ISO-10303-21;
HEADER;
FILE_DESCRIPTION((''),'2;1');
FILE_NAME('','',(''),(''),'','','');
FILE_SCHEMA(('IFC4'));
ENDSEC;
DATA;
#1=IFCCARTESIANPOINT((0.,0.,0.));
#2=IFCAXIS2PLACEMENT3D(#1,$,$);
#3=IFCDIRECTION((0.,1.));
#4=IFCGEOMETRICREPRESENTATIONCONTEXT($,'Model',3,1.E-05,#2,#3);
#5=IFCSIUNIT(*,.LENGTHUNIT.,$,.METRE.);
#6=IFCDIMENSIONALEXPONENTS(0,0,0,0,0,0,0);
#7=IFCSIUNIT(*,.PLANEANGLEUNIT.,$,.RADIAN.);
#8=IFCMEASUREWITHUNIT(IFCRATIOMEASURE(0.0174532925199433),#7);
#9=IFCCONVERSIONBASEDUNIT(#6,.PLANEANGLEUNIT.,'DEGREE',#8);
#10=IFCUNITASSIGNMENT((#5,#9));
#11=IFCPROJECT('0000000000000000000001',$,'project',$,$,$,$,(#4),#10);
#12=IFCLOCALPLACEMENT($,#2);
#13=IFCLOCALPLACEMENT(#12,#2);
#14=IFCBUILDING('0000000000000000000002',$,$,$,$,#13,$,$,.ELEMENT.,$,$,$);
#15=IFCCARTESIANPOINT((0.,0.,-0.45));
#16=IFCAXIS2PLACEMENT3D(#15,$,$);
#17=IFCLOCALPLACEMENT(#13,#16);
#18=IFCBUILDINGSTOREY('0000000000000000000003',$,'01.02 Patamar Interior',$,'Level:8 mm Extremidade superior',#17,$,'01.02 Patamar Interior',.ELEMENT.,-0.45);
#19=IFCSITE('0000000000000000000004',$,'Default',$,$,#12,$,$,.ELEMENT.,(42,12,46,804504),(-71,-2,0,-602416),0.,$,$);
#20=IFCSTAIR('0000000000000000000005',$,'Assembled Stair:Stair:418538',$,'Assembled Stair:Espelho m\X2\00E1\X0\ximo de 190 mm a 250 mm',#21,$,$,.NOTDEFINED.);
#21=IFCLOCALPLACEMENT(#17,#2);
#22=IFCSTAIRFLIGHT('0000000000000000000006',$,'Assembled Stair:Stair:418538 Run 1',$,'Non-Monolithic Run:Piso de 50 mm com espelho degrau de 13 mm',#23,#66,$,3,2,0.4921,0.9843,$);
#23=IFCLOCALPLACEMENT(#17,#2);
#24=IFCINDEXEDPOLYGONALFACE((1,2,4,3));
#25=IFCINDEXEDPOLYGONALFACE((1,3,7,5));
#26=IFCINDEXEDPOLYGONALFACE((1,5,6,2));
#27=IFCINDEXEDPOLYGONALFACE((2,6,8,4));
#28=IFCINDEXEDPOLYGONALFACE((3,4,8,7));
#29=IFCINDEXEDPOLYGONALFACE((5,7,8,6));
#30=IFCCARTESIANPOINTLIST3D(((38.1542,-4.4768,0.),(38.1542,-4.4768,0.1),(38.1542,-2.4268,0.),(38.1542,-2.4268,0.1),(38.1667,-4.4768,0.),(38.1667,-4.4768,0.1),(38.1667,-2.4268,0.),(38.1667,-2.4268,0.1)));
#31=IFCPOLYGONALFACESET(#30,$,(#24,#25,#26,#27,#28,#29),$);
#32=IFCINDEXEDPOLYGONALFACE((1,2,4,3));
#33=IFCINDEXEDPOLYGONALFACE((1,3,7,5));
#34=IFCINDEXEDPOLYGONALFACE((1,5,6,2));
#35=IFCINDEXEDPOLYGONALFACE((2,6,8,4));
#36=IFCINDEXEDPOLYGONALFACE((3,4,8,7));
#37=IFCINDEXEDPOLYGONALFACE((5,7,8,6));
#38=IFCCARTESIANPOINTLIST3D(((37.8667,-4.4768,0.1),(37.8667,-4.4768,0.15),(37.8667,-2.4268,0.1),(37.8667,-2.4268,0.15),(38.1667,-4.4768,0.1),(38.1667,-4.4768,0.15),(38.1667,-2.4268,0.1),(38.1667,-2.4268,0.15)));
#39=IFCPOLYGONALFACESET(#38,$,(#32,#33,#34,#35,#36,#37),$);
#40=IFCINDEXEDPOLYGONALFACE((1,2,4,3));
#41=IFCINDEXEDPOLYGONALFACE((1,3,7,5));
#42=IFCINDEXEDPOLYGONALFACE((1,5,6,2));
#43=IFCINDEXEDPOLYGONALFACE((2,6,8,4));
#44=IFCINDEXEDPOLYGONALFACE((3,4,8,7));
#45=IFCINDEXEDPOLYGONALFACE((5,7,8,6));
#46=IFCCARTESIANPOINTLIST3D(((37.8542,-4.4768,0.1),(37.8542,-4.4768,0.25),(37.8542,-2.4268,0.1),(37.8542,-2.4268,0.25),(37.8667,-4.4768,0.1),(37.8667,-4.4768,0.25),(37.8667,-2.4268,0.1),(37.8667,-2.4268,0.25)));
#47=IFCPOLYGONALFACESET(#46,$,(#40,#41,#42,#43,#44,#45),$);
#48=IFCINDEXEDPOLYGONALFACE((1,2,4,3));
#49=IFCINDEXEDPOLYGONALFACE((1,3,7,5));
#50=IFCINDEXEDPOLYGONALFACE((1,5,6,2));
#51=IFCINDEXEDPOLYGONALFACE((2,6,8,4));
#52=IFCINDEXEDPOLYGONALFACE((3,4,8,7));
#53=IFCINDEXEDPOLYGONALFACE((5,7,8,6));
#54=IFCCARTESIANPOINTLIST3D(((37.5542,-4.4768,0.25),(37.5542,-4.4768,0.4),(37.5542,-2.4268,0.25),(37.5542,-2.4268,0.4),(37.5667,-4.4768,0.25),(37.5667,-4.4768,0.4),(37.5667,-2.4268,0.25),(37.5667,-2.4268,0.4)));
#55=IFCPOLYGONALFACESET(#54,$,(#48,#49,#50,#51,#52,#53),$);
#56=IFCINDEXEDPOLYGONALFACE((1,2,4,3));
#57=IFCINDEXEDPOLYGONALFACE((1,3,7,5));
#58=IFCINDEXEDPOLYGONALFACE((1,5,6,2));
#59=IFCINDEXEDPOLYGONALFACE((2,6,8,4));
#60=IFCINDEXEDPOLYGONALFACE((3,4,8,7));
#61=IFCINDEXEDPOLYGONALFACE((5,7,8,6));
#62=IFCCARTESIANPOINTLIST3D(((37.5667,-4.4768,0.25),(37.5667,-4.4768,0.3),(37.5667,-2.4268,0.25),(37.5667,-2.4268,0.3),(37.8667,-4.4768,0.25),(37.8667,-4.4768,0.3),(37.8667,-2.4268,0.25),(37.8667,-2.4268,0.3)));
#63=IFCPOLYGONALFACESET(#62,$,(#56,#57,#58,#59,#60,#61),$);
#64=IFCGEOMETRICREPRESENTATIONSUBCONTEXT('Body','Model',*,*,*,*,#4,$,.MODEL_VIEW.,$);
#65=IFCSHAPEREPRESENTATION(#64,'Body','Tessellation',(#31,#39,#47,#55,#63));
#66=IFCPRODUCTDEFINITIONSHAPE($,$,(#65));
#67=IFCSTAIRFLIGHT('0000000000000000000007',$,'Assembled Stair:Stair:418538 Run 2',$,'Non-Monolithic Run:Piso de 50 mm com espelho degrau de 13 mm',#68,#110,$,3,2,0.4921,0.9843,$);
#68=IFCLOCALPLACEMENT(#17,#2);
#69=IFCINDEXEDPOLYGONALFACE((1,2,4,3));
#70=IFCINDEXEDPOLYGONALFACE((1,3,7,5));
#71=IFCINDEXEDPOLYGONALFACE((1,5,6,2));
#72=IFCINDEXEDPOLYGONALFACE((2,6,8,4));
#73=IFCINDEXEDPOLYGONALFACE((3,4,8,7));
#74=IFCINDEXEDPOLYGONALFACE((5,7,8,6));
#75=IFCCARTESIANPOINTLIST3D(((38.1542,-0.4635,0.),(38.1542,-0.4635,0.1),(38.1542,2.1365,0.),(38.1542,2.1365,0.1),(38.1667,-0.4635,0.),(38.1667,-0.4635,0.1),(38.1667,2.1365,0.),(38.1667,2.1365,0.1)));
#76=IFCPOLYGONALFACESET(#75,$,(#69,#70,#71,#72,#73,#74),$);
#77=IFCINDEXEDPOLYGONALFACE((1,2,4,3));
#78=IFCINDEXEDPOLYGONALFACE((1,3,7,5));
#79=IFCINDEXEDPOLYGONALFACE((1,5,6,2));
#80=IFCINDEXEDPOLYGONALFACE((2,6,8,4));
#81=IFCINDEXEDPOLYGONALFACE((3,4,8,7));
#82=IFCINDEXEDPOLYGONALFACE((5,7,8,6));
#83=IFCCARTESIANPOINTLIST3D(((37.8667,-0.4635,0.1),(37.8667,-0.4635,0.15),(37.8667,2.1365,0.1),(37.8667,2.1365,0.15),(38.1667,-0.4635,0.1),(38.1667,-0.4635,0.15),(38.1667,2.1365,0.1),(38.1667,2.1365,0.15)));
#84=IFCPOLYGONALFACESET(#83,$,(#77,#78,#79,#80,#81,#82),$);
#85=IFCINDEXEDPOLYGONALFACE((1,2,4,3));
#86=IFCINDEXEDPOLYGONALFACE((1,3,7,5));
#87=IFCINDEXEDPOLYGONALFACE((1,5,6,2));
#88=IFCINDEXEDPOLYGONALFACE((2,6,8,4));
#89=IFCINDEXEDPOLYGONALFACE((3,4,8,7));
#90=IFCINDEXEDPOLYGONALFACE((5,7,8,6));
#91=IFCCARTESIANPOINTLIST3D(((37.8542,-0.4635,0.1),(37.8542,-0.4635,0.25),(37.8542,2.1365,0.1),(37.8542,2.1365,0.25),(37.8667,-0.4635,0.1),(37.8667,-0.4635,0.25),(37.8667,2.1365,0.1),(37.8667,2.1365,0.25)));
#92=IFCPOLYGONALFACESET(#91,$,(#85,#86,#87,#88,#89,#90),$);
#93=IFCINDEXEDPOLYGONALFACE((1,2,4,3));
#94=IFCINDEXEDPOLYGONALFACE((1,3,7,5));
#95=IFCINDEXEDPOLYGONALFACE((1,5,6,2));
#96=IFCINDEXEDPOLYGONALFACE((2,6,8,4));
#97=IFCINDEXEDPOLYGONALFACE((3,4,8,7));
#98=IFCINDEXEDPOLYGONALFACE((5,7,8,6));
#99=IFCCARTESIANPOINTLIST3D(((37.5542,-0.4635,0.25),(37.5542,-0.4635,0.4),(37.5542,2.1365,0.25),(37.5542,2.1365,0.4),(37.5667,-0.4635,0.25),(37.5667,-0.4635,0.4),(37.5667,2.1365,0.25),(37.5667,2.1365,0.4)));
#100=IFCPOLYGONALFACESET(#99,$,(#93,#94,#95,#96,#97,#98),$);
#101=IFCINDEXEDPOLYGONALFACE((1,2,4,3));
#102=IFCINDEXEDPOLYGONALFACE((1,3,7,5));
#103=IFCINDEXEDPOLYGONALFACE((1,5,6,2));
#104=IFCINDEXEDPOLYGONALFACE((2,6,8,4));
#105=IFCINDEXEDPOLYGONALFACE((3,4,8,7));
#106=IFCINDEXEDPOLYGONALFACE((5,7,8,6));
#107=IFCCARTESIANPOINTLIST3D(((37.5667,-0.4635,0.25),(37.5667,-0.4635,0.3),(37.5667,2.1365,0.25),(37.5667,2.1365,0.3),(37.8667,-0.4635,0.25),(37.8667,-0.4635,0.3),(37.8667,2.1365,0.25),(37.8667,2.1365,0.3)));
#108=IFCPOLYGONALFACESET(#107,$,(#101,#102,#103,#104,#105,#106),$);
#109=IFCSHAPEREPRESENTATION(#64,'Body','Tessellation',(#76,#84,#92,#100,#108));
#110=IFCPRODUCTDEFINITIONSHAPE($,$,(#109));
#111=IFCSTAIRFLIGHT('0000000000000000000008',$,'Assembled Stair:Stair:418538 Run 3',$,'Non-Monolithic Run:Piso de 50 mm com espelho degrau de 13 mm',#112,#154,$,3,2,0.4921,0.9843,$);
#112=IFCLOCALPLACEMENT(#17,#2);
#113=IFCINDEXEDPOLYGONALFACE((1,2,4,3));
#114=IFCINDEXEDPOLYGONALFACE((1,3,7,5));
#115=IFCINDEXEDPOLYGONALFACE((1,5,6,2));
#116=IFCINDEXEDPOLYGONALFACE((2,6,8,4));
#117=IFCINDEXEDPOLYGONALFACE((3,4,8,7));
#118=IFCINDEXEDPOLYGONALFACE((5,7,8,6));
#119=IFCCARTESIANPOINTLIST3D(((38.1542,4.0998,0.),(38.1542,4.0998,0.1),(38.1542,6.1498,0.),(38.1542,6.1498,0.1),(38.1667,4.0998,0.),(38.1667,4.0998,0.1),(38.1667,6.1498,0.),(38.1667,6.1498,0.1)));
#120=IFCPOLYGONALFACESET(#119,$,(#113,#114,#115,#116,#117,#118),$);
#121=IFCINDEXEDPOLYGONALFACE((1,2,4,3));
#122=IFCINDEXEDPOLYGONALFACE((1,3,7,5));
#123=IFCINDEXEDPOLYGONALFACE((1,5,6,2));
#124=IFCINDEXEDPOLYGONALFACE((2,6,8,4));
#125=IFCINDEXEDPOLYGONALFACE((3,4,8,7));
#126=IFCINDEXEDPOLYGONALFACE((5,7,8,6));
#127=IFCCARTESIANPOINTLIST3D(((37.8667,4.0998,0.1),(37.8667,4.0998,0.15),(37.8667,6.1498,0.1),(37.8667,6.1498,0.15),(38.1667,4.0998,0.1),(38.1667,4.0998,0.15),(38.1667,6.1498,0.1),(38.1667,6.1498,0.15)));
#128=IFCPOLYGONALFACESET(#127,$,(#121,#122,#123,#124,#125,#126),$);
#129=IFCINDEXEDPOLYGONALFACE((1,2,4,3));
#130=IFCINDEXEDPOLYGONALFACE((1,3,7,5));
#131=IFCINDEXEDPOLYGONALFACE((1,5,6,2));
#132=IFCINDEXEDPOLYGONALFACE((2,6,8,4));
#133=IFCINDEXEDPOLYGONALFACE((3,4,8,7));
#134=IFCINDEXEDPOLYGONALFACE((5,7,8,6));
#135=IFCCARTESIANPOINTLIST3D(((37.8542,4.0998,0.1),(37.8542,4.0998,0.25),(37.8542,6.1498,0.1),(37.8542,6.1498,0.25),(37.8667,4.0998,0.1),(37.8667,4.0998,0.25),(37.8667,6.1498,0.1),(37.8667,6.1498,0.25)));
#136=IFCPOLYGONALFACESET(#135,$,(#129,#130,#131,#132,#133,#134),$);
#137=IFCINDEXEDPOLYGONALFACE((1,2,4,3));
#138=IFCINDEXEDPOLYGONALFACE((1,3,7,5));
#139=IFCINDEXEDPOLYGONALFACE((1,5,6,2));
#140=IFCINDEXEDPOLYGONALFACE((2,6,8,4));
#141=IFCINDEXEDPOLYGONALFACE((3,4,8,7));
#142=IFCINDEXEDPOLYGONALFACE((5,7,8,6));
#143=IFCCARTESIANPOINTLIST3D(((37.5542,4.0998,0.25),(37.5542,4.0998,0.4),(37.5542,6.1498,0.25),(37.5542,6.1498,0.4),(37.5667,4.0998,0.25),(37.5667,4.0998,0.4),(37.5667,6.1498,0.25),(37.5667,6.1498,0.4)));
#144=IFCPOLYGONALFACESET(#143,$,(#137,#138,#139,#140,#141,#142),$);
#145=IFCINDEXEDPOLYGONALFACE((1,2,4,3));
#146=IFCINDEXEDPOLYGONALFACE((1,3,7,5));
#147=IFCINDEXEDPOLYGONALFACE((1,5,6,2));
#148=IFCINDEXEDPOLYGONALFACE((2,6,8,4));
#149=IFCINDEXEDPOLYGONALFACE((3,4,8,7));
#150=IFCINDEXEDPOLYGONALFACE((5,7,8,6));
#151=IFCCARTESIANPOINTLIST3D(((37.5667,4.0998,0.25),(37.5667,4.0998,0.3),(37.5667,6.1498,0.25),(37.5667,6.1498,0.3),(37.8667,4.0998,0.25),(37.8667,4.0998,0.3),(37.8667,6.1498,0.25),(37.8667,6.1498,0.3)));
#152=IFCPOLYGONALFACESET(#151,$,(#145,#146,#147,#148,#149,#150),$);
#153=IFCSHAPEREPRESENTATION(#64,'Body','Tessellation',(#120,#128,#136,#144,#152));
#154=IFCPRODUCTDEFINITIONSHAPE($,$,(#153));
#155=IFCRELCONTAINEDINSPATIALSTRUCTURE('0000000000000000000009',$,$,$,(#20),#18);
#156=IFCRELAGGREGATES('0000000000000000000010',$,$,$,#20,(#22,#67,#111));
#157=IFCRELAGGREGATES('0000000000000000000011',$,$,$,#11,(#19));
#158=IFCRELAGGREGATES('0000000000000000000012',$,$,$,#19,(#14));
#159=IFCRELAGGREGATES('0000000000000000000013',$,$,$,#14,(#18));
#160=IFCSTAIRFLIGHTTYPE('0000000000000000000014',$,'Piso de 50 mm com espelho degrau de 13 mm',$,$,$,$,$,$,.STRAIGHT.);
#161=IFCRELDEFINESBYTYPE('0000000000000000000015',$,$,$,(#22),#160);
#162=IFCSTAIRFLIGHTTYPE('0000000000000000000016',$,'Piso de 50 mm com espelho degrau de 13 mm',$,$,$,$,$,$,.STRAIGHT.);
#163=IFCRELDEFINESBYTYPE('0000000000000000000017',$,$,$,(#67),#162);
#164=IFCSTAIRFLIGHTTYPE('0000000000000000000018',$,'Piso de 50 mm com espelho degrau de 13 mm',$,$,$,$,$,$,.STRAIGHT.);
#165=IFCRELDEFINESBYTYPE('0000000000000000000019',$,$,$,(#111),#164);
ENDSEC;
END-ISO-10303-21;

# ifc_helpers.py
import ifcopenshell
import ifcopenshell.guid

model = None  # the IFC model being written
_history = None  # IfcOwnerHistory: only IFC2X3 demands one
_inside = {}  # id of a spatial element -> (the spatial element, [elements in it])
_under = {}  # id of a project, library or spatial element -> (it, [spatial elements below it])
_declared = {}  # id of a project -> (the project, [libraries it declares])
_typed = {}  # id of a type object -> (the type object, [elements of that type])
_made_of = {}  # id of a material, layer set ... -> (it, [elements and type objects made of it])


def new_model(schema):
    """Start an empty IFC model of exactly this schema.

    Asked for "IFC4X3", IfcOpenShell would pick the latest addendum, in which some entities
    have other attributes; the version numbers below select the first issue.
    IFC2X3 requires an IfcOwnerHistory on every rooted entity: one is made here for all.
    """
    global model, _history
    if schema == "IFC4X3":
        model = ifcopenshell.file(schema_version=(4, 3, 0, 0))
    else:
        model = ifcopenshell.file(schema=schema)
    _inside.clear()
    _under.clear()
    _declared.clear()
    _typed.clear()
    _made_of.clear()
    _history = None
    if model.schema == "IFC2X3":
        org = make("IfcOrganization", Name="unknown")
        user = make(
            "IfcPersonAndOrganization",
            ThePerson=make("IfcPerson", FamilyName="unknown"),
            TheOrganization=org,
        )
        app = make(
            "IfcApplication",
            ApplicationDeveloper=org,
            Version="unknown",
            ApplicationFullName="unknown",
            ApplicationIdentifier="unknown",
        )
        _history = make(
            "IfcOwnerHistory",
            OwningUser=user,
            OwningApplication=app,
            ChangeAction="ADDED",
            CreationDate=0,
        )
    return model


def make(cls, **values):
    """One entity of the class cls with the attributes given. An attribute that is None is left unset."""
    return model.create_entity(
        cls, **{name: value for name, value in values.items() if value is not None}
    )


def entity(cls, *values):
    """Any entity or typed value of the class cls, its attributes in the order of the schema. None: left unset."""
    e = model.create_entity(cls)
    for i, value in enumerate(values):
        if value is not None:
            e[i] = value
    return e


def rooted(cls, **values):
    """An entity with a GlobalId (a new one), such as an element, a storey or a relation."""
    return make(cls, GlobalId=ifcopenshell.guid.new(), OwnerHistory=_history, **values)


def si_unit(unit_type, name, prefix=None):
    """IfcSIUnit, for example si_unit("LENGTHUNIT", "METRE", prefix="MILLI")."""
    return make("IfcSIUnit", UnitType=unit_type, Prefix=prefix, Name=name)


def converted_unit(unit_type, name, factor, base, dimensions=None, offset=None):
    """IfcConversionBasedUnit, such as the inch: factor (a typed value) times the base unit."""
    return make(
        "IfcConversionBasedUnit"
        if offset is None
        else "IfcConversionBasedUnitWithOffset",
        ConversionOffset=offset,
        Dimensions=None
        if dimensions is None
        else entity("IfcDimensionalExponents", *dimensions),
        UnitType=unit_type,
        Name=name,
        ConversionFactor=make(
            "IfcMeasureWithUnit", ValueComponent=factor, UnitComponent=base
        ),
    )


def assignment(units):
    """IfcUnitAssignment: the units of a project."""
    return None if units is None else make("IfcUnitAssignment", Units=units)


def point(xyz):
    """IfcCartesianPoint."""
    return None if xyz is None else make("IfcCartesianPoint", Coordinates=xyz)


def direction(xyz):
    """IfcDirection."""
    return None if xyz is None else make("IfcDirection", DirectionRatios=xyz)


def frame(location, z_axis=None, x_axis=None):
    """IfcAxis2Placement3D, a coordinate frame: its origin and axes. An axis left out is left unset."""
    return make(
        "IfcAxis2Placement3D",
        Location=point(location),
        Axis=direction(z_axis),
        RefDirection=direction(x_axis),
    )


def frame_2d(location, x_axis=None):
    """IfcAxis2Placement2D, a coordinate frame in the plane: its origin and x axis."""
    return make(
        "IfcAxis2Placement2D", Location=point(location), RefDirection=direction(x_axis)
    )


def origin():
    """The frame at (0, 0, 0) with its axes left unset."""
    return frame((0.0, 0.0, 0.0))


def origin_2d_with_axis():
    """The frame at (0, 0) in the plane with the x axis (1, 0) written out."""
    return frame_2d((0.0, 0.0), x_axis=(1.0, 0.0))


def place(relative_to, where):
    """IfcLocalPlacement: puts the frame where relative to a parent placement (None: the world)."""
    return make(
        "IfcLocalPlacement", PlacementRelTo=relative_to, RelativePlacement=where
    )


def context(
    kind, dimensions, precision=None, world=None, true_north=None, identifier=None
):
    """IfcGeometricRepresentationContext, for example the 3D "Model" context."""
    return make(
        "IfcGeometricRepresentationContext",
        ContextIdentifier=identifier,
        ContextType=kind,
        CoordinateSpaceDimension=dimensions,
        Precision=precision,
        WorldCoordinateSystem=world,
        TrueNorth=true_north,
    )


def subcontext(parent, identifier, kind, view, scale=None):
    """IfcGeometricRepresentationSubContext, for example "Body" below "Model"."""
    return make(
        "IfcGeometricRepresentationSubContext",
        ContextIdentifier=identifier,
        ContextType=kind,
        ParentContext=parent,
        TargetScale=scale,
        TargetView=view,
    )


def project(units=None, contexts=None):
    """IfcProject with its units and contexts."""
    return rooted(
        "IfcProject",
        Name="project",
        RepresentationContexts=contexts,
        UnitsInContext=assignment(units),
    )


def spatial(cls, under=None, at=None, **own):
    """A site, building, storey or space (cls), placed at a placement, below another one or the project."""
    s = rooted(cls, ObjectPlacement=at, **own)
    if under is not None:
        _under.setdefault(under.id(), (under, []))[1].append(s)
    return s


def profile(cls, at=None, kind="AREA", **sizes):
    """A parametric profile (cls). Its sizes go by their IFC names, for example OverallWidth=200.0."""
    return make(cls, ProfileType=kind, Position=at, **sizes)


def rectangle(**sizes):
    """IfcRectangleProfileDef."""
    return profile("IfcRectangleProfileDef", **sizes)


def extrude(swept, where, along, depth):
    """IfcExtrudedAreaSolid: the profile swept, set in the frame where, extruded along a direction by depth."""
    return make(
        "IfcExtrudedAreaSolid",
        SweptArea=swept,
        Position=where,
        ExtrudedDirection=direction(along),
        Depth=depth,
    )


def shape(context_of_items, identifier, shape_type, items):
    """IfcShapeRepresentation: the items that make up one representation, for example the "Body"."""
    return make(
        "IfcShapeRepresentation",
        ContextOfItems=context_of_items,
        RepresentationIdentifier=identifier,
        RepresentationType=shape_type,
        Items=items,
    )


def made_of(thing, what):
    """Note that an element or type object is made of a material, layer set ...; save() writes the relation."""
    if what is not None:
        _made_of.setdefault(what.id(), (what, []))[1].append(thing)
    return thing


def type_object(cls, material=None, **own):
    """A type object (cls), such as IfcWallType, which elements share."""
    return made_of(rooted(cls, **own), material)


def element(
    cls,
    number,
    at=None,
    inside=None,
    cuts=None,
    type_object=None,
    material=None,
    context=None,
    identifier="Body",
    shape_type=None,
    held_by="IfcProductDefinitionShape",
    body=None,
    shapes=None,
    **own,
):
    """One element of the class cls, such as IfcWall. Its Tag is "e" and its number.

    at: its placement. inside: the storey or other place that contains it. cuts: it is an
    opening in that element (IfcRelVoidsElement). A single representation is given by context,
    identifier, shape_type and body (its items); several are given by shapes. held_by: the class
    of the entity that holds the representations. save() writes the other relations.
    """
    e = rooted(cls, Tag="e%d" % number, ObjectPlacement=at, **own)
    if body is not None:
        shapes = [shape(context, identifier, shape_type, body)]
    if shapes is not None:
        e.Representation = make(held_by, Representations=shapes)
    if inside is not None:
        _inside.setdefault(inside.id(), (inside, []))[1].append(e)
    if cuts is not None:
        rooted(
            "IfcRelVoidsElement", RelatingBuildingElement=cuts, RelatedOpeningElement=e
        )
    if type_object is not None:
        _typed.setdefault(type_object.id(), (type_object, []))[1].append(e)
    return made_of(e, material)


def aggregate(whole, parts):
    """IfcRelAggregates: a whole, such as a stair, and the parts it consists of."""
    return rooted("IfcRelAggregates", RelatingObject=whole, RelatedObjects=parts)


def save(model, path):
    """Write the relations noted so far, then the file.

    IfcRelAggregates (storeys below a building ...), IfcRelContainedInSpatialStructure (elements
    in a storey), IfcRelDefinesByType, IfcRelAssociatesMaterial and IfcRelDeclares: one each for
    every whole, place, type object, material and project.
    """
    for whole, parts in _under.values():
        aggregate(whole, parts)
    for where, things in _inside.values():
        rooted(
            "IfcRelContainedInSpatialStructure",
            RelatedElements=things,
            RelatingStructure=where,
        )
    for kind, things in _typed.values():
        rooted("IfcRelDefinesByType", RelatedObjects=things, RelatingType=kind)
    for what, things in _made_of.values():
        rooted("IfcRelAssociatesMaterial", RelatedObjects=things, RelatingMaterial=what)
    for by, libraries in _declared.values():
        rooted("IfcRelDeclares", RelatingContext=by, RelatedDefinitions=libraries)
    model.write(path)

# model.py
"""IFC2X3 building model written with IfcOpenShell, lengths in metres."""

from ifc_helpers import new_model, entity, si_unit, converted_unit, direction, frame, frame_2d, origin, origin_2d_with_axis, place, context, subcontext, project, spatial, rectangle, extrude, type_object, element, aggregate, save


model = new_model("IFC2X3")

# Units and contexts
model_context = context("Model", 3, precision=1e-05, world=origin(), true_north=direction((0.0, 1.0)))
body_context = subcontext(model_context, "Body", "Model", "MODEL_VIEW")
ifc_project = project(units=[si_unit("LENGTHUNIT", "METRE"), converted_unit("PLANEANGLEUNIT", "DEGREE", entity("IfcRatioMeasure", 0.0174532925199433), si_unit("PLANEANGLEUNIT", "RADIAN"), dimensions=[0, 0, 0, 0, 0, 0, 0])], contexts=[model_context])

# Site, building, storey
site_placement = place(None, origin())
site = spatial("IfcSite", under=ifc_project, at=site_placement, Name="Default", CompositionType="ELEMENT", RefLatitude=(42, 12, 46, 804504), RefLongitude=(-71, -2, 0, -602416), RefElevation=0.0)
building_placement = place(site_placement, origin())
building = spatial("IfcBuilding", under=site, at=building_placement, CompositionType="ELEMENT")
storey_placement = place(building_placement, frame((0.0, 0.0, -0.45)))
storey = spatial("IfcBuildingStorey", under=building, at=storey_placement, Name="01.02 Patamar Interior", ObjectType="Level:8 mm Extremidade superior", LongName="01.02 Patamar Interior", CompositionType="ELEMENT", Elevation=-0.45)

# Stair, stair flights
stair_placement = place(storey_placement, origin())
stair = element("IfcStair", 1, at=stair_placement, inside=storey, Name="Assembled Stair:Stair:418538", ObjectType="Assembled Stair:Espelho máximo de 190 mm a 250 mm", ShapeType="NOTDEFINED")
stair_flight_type_1 = type_object("IfcStairFlightType", Name="Piso de 50 mm com espelho degrau de 13 mm", PredefinedType="STRAIGHT")
stair_flight_1_placement = place(stair_placement, frame((37.5542, -4.4768, 0.0)))
stair_flight_1 = element("IfcStairFlight", 2, at=stair_flight_1_placement, type_object=stair_flight_type_1, Name="Assembled Stair:Stair:418538 Run 1", ObjectType="Non-Monolithic Run:Piso de 50 mm com espelho degrau de 13 mm", NumberOfRiser=3, NumberOfTreads=2, RiserHeight=0.4921, TreadLength=0.9843, context=body_context, shape_type="SweptSolid", body=[
    extrude(rectangle(XDim=2.05, YDim=0.0125, at=frame_2d((0.0, 0.0), x_axis=(1.0, 0.0))), frame((0.6063, 1.025, 0.0), z_axis=(0.0, 0.0, 1.0), x_axis=(0.0, -1.0, 0.0)), (0.0, 0.0, 1.0), 0.1),
    extrude(rectangle(XDim=0.3, YDim=2.05, at=frame_2d((0.0, 0.0), x_axis=(1.0, 0.0))), frame((0.4625, 1.025, 0.1)), (0.0, 0.0, 1.0), 0.05),
    extrude(rectangle(XDim=2.05, YDim=0.0125, at=frame_2d((0.0, 0.0), x_axis=(1.0, 0.0))), frame((0.3063, 1.025, 0.1), z_axis=(0.0, 0.0, 1.0), x_axis=(0.0, -1.0, 0.0)), (0.0, 0.0, 1.0), 0.15),
    extrude(rectangle(XDim=2.05, YDim=0.0125, at=frame_2d((0.0, 0.0), x_axis=(1.0, 0.0))), frame((0.0063, 1.025, 0.25), z_axis=(0.0, 0.0, 1.0), x_axis=(0.0, -1.0, 0.0)), (0.0, 0.0, 1.0), 0.15),
    extrude(rectangle(XDim=0.3, YDim=2.05, at=frame_2d((0.0, 0.0), x_axis=(1.0, 0.0))), frame((0.1625, 1.025, 0.25)), (0.0, 0.0, 1.0), 0.05),
])
stair_flight_type_2 = type_object("IfcStairFlightType", Name="Piso de 50 mm com espelho degrau de 13 mm", PredefinedType="STRAIGHT")
stair_flight_2_placement = place(stair_placement, frame((37.5542, -0.4635, 0.0)))
stair_flight_2 = element("IfcStairFlight", 3, at=stair_flight_2_placement, type_object=stair_flight_type_2, Name="Assembled Stair:Stair:418538 Run 2", ObjectType="Non-Monolithic Run:Piso de 50 mm com espelho degrau de 13 mm", NumberOfRiser=3, NumberOfTreads=2, RiserHeight=0.4921, TreadLength=0.9843, context=body_context, shape_type="SweptSolid", body=[
    extrude(rectangle(XDim=2.6, YDim=0.0125, at=frame_2d((0.0, 0.0), x_axis=(1.0, 0.0))), frame((0.6063, 1.3, 0.0), z_axis=(0.0, 0.0, 1.0), x_axis=(0.0, -1.0, 0.0)), (0.0, 0.0, 1.0), 0.1),
    extrude(rectangle(XDim=0.3, YDim=2.6, at=origin_2d_with_axis()), frame((0.4625, 1.3, 0.1)), (0.0, 0.0, 1.0), 0.05),
    extrude(rectangle(XDim=2.6, YDim=0.0125, at=frame_2d((0.0, 0.0), x_axis=(1.0, 0.0))), frame((0.3063, 1.3, 0.1), z_axis=(0.0, 0.0, 1.0), x_axis=(0.0, -1.0, 0.0)), (0.0, 0.0, 1.0), 0.15),
    extrude(rectangle(XDim=2.6, YDim=0.0125, at=frame_2d((0.0, 0.0), x_axis=(1.0, 0.0))), frame((0.0063, 1.3, 0.25), z_axis=(0.0, 0.0, 1.0), x_axis=(0.0, -1.0, 0.0)), (0.0, 0.0, 1.0), 0.15),
    extrude(rectangle(XDim=0.3, YDim=2.6, at=frame_2d((0.0, 0.0), x_axis=(1.0, 0.0))), frame((0.1625, 1.3, 0.25)), (0.0, 0.0, 1.0), 0.05),
])
stair_flight_type_3 = type_object("IfcStairFlightType", Name="Piso de 50 mm com espelho degrau de 13 mm", PredefinedType="STRAIGHT")
stair_flight_3_placement = place(stair_placement, frame((37.5542, 4.0998, 0.0)))
stair_flight_3 = element("IfcStairFlight", 4, at=stair_flight_3_placement, type_object=stair_flight_type_3, Name="Assembled Stair:Stair:418538 Run 3", ObjectType="Non-Monolithic Run:Piso de 50 mm com espelho degrau de 13 mm", NumberOfRiser=3, NumberOfTreads=2, RiserHeight=0.4921, TreadLength=0.9843, context=body_context, shape_type="SweptSolid", body=[
    extrude(rectangle(XDim=2.05, YDim=0.0125, at=frame_2d((0.0, 0.0), x_axis=(1.0, 0.0))), frame((0.6063, 1.025, 0.0), z_axis=(0.0, 0.0, 1.0), x_axis=(0.0, -1.0, 0.0)), (0.0, 0.0, 1.0), 0.1),
    extrude(rectangle(XDim=0.3, YDim=2.05, at=frame_2d((0.0, 0.0), x_axis=(1.0, 0.0))), frame((0.4625, 1.025, 0.1)), (0.0, 0.0, 1.0), 0.05),
    extrude(rectangle(XDim=2.05, YDim=0.0125, at=frame_2d((0.0, 0.0), x_axis=(1.0, 0.0))), frame((0.3062, 1.025, 0.1), z_axis=(0.0, 0.0, 1.0), x_axis=(0.0, -1.0, 0.0)), (0.0, 0.0, 1.0), 0.15),
    extrude(rectangle(XDim=2.05, YDim=0.0125, at=frame_2d((0.0, 0.0), x_axis=(1.0, 0.0))), frame((0.0063, 1.025, 0.25), z_axis=(0.0, 0.0, 1.0), x_axis=(0.0, -1.0, 0.0)), (0.0, 0.0, 1.0), 0.15),
    extrude(rectangle(XDim=0.3, YDim=2.05, at=frame_2d((0.0, 0.0), x_axis=(1.0, 0.0))), frame((0.1625, 1.025, 0.25)), (0.0, 0.0, 1.0), 0.05),
])
aggregate(stair, [stair_flight_1, stair_flight_2, stair_flight_3])

save(model, "model.ifc")
